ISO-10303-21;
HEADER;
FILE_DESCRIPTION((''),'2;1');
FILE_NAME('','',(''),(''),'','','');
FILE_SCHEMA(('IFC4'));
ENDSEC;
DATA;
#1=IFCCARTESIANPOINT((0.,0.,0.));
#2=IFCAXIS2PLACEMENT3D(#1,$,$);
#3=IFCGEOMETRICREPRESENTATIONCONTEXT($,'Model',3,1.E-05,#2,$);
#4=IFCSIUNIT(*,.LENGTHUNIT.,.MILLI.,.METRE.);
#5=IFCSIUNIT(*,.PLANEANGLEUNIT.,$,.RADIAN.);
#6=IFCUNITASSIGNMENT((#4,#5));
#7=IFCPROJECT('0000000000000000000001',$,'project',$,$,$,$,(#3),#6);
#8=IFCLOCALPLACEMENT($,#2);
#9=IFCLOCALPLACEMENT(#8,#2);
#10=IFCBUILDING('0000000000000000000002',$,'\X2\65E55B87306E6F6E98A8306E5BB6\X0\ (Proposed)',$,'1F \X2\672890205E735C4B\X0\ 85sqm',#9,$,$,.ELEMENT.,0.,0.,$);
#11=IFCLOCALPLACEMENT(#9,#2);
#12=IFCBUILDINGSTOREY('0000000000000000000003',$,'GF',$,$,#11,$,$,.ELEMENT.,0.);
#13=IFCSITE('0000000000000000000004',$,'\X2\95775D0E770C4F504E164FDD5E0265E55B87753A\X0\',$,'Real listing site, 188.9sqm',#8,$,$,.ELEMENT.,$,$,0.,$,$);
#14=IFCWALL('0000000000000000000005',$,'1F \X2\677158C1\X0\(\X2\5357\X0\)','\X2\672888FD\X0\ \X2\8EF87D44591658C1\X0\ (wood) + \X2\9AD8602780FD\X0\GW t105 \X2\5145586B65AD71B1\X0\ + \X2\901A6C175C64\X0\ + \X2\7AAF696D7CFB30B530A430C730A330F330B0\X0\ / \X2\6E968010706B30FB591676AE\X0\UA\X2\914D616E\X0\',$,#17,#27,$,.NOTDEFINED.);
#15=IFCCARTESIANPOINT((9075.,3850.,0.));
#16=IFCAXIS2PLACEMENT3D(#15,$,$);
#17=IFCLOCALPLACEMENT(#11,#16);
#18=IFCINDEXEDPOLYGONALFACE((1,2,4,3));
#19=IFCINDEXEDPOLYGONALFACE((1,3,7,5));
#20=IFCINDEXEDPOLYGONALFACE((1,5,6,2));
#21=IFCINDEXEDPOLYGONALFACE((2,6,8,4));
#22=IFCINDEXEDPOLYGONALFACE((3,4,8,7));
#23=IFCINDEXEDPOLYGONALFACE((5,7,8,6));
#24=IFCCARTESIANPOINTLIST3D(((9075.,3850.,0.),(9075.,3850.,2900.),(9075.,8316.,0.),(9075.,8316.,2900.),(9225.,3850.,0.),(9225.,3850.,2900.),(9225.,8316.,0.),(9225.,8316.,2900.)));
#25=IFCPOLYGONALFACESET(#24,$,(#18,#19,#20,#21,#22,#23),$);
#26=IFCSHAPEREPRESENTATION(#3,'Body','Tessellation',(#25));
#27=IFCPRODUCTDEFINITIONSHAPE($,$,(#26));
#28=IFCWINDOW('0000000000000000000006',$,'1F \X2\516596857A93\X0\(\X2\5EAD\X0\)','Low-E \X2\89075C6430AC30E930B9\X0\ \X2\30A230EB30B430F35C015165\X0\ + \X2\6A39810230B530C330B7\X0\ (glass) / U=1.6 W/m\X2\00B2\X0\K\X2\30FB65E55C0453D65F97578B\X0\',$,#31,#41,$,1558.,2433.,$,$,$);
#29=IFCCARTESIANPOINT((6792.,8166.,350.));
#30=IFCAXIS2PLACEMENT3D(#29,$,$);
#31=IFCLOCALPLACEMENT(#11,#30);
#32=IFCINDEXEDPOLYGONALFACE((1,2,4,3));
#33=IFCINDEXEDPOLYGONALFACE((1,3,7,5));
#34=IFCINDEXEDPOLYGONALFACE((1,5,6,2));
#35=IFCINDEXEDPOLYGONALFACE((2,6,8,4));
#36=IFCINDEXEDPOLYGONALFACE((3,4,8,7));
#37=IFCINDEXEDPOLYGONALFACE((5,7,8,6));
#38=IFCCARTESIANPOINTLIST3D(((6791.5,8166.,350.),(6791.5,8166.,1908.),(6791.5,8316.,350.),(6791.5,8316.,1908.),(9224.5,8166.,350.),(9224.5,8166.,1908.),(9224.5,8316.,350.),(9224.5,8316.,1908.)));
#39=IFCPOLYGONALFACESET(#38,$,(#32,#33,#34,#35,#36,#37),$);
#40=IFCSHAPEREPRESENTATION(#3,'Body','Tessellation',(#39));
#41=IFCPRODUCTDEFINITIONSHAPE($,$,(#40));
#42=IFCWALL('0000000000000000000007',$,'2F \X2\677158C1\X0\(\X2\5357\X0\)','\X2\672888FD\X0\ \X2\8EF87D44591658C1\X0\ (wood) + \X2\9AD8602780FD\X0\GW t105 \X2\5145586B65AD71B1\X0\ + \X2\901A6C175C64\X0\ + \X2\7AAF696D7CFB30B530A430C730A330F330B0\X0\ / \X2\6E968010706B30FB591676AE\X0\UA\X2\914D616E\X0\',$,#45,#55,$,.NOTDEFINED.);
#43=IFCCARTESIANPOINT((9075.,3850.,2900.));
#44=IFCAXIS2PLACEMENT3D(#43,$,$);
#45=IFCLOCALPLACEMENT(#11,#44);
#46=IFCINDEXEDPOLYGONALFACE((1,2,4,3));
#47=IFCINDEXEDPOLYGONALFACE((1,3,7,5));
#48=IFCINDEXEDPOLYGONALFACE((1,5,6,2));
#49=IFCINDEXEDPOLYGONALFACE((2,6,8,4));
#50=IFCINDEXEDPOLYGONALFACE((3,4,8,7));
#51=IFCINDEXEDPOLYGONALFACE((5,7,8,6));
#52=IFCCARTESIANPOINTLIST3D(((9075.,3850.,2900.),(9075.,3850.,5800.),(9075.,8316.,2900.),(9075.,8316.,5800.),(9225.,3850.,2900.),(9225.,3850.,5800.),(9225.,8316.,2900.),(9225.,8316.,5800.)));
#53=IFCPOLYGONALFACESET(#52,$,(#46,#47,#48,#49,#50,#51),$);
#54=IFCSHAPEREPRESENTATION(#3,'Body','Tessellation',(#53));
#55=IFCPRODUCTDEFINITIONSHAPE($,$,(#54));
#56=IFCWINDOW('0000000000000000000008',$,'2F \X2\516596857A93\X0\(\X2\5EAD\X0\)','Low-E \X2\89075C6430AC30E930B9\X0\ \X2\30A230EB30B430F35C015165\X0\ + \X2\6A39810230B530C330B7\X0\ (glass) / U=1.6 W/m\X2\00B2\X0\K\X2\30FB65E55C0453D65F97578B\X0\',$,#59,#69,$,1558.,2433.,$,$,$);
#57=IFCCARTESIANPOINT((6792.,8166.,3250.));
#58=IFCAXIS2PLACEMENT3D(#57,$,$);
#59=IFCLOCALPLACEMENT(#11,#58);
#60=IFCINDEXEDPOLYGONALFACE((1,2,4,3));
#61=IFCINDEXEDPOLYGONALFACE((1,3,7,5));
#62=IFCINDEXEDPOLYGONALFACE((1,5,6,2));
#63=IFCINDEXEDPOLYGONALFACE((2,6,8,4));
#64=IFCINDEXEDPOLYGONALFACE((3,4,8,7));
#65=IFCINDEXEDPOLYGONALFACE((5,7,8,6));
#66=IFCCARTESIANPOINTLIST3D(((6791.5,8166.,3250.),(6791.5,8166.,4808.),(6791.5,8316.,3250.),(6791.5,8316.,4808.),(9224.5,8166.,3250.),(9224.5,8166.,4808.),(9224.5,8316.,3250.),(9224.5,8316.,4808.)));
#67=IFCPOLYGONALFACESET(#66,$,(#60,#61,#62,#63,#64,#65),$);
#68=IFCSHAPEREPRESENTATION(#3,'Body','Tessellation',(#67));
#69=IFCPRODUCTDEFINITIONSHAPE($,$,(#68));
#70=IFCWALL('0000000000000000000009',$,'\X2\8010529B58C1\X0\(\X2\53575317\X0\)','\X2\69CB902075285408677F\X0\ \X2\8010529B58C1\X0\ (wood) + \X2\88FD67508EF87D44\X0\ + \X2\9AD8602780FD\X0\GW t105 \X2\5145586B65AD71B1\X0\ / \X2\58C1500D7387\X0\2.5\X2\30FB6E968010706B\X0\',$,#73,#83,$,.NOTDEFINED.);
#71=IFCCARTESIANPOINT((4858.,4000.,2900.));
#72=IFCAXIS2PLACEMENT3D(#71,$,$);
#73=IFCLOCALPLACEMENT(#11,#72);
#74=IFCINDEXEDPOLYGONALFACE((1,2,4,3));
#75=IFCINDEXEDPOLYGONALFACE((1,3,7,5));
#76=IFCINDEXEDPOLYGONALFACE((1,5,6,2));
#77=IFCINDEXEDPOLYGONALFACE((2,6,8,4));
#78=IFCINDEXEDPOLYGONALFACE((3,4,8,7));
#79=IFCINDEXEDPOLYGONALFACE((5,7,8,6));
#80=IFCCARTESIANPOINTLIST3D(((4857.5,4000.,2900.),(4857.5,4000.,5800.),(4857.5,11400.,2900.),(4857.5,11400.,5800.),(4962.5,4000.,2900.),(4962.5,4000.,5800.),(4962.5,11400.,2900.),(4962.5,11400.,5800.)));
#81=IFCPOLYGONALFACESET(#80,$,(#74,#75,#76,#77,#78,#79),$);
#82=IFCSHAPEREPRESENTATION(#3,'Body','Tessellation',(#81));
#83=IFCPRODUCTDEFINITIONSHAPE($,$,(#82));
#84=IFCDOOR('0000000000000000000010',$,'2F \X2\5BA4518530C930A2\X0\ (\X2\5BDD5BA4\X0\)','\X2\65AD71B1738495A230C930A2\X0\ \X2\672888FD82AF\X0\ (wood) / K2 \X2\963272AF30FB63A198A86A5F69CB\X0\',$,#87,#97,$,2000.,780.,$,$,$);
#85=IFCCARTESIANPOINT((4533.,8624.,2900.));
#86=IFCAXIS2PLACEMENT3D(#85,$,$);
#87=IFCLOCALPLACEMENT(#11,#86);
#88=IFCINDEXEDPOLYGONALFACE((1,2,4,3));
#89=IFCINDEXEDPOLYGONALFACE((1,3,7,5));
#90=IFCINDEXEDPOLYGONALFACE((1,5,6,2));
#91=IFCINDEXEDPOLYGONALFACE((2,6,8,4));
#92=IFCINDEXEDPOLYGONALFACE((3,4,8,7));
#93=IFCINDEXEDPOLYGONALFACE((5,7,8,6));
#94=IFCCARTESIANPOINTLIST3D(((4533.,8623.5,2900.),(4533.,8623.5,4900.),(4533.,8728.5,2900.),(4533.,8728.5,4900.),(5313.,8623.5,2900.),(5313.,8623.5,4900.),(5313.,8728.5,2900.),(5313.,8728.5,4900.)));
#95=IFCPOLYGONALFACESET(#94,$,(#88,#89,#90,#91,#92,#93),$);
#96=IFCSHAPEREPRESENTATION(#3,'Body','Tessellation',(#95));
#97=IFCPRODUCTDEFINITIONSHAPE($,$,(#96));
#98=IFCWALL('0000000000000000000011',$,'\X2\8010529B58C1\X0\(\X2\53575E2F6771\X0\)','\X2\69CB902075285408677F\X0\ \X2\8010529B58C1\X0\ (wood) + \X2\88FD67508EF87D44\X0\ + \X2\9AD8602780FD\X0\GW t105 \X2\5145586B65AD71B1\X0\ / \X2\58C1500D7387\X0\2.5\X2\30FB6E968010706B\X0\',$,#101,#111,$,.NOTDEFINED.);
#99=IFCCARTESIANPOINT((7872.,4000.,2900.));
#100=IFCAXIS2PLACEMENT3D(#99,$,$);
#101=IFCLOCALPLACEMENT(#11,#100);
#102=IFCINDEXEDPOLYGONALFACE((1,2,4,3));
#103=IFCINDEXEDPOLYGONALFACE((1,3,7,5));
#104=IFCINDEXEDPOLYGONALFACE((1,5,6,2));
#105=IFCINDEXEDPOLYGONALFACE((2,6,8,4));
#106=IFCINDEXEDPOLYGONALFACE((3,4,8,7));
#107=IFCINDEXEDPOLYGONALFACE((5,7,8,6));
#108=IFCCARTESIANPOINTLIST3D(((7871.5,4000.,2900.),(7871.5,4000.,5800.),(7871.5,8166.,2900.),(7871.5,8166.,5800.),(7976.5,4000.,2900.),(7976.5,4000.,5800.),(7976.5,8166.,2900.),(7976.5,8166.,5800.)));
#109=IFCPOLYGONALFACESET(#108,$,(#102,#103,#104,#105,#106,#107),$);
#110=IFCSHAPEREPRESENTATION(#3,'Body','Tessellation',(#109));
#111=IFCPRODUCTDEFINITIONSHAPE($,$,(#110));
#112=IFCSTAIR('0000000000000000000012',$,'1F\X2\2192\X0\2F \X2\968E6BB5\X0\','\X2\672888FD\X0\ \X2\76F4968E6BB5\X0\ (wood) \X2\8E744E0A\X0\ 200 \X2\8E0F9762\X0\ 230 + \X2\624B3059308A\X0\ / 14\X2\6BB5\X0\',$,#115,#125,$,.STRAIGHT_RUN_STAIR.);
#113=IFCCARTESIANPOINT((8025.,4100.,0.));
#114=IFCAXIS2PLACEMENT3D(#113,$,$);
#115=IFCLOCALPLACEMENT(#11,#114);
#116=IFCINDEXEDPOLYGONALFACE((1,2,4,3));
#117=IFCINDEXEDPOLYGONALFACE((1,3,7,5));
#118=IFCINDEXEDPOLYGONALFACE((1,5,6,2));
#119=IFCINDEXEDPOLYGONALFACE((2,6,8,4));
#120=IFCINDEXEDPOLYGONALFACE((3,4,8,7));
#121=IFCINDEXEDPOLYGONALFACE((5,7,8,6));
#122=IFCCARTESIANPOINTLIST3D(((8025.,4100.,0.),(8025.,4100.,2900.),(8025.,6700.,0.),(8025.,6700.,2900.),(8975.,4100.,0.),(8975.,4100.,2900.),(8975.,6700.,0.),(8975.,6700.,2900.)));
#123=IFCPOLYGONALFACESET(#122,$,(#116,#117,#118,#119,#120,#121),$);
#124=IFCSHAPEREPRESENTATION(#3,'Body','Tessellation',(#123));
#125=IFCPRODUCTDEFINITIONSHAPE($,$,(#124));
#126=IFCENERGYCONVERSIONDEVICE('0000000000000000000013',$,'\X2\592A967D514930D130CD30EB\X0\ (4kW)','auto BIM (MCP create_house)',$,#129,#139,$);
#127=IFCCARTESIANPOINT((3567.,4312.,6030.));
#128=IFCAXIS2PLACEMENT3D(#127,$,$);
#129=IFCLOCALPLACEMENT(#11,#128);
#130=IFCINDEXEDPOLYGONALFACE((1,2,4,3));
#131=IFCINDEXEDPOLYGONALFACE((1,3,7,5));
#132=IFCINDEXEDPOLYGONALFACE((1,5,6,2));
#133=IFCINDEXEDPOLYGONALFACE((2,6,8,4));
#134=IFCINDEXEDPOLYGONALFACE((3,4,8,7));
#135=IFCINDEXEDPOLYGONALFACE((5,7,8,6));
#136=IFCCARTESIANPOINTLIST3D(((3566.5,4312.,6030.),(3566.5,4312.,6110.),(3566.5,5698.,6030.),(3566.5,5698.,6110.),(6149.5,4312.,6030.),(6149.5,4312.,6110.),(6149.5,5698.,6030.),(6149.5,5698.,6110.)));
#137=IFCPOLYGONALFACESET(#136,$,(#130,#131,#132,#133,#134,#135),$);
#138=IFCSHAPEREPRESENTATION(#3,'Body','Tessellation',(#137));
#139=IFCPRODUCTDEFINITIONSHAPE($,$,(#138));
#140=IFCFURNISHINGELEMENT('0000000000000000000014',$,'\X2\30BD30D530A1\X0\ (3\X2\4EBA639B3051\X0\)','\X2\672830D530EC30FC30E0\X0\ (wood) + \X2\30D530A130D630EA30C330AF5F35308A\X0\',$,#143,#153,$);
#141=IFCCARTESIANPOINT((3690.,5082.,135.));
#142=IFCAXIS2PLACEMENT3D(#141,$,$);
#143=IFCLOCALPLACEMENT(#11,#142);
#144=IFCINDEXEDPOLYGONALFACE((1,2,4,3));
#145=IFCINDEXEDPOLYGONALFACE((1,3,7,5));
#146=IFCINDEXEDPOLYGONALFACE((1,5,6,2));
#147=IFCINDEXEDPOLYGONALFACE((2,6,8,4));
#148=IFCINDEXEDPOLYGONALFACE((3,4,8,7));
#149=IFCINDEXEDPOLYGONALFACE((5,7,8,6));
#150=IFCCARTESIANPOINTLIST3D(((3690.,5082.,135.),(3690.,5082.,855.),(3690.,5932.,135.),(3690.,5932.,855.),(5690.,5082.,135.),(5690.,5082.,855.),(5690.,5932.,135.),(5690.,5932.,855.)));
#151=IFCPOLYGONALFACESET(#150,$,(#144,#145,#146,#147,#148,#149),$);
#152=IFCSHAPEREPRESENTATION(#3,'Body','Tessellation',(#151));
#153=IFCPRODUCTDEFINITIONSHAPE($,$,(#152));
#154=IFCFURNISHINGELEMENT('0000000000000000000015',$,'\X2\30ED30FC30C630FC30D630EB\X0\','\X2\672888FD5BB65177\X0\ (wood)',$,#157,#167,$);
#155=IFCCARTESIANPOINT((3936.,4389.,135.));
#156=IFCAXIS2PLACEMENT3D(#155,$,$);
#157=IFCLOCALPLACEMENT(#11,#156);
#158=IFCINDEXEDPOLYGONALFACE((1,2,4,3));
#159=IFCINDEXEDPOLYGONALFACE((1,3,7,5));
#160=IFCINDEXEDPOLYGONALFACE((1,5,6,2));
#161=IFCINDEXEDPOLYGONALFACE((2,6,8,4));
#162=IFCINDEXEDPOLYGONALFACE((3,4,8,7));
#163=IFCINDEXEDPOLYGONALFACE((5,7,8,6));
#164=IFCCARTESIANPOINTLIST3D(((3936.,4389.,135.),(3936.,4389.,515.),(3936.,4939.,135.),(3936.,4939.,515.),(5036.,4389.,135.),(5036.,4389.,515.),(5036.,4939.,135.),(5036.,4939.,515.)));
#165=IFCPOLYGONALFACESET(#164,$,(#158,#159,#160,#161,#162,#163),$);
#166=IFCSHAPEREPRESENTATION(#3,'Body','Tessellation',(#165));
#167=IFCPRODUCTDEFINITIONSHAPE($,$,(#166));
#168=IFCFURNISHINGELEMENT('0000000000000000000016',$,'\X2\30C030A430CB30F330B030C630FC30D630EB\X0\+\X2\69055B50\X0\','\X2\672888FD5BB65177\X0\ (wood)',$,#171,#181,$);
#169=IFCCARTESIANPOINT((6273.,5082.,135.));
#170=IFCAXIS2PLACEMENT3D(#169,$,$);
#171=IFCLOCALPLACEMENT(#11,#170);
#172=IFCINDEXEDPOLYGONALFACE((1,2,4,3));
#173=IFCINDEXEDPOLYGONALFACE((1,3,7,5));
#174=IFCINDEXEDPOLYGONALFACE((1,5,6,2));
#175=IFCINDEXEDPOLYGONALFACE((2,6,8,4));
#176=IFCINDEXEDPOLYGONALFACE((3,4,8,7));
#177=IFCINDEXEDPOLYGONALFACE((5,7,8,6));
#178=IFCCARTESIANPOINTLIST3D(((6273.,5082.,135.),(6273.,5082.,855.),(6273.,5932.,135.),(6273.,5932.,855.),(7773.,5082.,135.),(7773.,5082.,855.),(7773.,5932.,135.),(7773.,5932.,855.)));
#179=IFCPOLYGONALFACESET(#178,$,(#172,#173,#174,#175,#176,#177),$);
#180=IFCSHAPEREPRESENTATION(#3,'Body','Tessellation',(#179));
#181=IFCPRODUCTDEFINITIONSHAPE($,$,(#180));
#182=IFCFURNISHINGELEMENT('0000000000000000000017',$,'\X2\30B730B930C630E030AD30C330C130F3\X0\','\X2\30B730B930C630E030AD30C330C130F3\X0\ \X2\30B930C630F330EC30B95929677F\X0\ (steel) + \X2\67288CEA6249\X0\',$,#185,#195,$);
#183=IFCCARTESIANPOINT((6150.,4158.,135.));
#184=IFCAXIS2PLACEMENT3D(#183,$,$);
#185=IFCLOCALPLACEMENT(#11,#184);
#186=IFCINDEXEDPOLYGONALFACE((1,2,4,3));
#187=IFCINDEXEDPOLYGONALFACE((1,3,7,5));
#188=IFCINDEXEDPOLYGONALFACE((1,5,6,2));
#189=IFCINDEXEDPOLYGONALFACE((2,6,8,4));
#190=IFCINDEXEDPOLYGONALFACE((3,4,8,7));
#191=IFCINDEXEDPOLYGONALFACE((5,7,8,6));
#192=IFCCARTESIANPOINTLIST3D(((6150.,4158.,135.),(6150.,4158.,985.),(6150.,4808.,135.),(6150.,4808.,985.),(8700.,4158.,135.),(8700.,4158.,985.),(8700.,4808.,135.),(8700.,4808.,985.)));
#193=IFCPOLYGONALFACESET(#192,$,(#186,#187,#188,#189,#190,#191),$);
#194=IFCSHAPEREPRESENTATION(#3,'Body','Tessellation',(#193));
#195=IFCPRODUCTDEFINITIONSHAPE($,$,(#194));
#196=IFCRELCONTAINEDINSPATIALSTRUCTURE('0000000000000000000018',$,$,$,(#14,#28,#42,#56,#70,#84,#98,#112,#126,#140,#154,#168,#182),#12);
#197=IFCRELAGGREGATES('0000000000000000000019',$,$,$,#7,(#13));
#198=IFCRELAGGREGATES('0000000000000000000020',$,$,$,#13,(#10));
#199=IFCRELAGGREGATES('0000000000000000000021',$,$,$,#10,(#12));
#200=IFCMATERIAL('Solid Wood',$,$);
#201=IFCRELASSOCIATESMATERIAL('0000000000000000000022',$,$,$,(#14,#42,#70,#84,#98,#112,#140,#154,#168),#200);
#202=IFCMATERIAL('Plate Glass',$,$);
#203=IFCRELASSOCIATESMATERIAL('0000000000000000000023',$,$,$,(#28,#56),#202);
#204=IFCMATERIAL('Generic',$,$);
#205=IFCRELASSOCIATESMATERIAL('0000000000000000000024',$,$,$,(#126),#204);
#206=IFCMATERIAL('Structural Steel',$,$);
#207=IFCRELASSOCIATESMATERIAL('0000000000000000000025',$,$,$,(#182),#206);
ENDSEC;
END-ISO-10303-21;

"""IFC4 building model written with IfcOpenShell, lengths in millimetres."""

from ifc_helpers import new_model, si_unit, frame, frame_2d, origin, place, context, project, spatial, rectangle, extrude, material, element, fill, save


model = new_model("IFC4")

# Units and contexts
model_context = context("Model", 3, precision=1e-05, world=origin())
ifc_project = project(units=[si_unit("LENGTHUNIT", "METRE", prefix="MILLI"), si_unit("PLANEANGLEUNIT", "RADIAN")], contexts=[model_context])

# Site, building, storey
site_placement = place(None, origin())
site = spatial("IfcSite", under=ifc_project, at=site_placement, Name="長崎県佐世保市日宇町", ObjectType="Real listing site, 188.9sqm", CompositionType="ELEMENT", RefElevation=0.0)
building_placement = place(site_placement, origin())
building = spatial("IfcBuilding", under=site, at=building_placement, Name="日宇の潮風の家 (Proposed)", ObjectType="1F 木造平屋 85sqm", CompositionType="ELEMENT", ElevationOfRefHeight=0.0, ElevationOfTerrain=0.0)
storey_placement = place(building_placement, origin())
storey = spatial("IfcBuildingStorey", under=building, at=storey_placement, Name="GF", CompositionType="ELEMENT", Elevation=0.0)

# Wall, opening, window
ifc_material_1 = material(Name="Solid Wood")
wall_1_placement = place(storey_placement, frame((9075.0, 3850.0, 0.0)))
wall_1 = element("IfcWall", 1, at=wall_1_placement, inside=storey, material=ifc_material_1, Name="1F 東壁(南)", Description="木製 軸組外壁 (wood) + 高性能GW t105 充填断熱 + 通気層 + 窯業系サイディング / 準耐火・外皮UA配慮", PredefinedType="NOTDEFINED", context=model_context, shape_type="SweptSolid", body=[
    extrude(rectangle(XDim=150.0, YDim=4466.0, at=frame_2d((75.0, 2233.0))), frame((9075.0, 3850.0, 0.0)), (0.0, 0.0, 1.0), 2900.0),
])
opening_1_placement = place(storey_placement, frame((6792.0, 8166.0, 350.0)))
opening_1 = element("IfcOpeningElement", 2, at=opening_1_placement, cuts=wall_1, PredefinedType="NOTDEFINED", context=model_context, shape_type="SweptSolid", body=[
    extrude(rectangle(XDim=2433.0, YDim=150.0, at=frame_2d((1216.0, 75.0))), frame((6792.0, 8166.0, 350.0)), (0.0, 0.0, 1.0), 1558.0),
])
ifc_material_2 = material(Name="Plate Glass")
window_1_placement = place(storey_placement, frame((6792.0, 8166.0, 350.0)))
window_1 = element("IfcWindow", 3, at=window_1_placement, inside=storey, material=ifc_material_2, Name="1F 入隅窓(庭)", Description="Low-E 複層ガラス アルゴン封入 + 樹脂サッシ (glass) / U=1.6 W/m²K・日射取得型", OverallHeight=1558.0, OverallWidth=2433.0, context=model_context, shape_type="SweptSolid", body=[
    extrude(rectangle(XDim=2433.0, YDim=150.0, at=frame_2d((1216.0, 75.0))), frame((6792.0, 8166.0, 350.0)), (0.0, 0.0, 1.0), 1558.0),
])
fill(opening_1, window_1)

# Wall, opening, window
wall_2_placement = place(storey_placement, frame((9075.0, 3850.0, 2900.0)))
wall_2 = element("IfcWall", 4, at=wall_2_placement, inside=storey, material=ifc_material_1, Name="2F 東壁(南)", Description="木製 軸組外壁 (wood) + 高性能GW t105 充填断熱 + 通気層 + 窯業系サイディング / 準耐火・外皮UA配慮", PredefinedType="NOTDEFINED", context=model_context, shape_type="SweptSolid", body=[
    extrude(rectangle(XDim=150.0, YDim=4466.0, at=frame_2d((75.0, 2233.0))), frame((9075.0, 3850.0, 2900.0)), (0.0, 0.0, 1.0), 2900.0),
])
opening_2_placement = place(storey_placement, frame((6792.0, 8166.0, 3250.0)))
opening_2 = element("IfcOpeningElement", 5, at=opening_2_placement, cuts=wall_2, PredefinedType="NOTDEFINED", context=model_context, shape_type="SweptSolid", body=[
    extrude(rectangle(XDim=2433.0, YDim=150.0, at=frame_2d((1216.0, 75.0))), frame((6792.0, 8166.0, 3250.0)), (0.0, 0.0, 1.0), 1558.0),
])
window_2_placement = place(storey_placement, frame((6792.0, 8166.0, 3250.0)))
window_2 = element("IfcWindow", 6, at=window_2_placement, inside=storey, material=ifc_material_2, Name="2F 入隅窓(庭)", Description="Low-E 複層ガラス アルゴン封入 + 樹脂サッシ (glass) / U=1.6 W/m²K・日射取得型", OverallHeight=1558.0, OverallWidth=2433.0, context=model_context, shape_type="SweptSolid", body=[
    extrude(rectangle(XDim=2433.0, YDim=150.0, at=frame_2d((1216.0, 75.0))), frame((6792.0, 8166.0, 3250.0)), (0.0, 0.0, 1.0), 1558.0),
])
fill(opening_2, window_2)

# Wall, opening, door
wall_3_placement = place(storey_placement, frame((4858.0, 4000.0, 2900.0)))
wall_3 = element("IfcWall", 7, at=wall_3_placement, inside=storey, material=ifc_material_1, Name="耐力壁(南北)", Description="構造用合板 耐力壁 (wood) + 製材軸組 + 高性能GW t105 充填断熱 / 壁倍率2.5・準耐火", PredefinedType="NOTDEFINED", context=model_context, shape_type="SweptSolid", body=[
    extrude(rectangle(XDim=105.0, YDim=7400.0, at=frame_2d((52.0, 3700.0))), frame((4858.0, 4000.0, 2900.0)), (0.0, 0.0, 1.0), 2900.0),
])
opening_3_placement = place(storey_placement, frame((4533.0, 8624.0, 2900.0)))
opening_3 = element("IfcOpeningElement", 8, at=opening_3_placement, cuts=wall_3, PredefinedType="NOTDEFINED", context=model_context, shape_type="SweptSolid", body=[
    extrude(rectangle(XDim=780.0, YDim=105.0, at=frame_2d((390.0, 52.0))), frame((4533.0, 8624.0, 2900.0)), (0.0, 0.0, 1.0), 2000.0),
])
door_1_placement = place(storey_placement, frame((4533.0, 8624.0, 2900.0)))
door_1 = element("IfcDoor", 9, at=door_1_placement, inside=storey, material=ifc_material_1, Name="2F 室内ドア (寝室)", Description="断熱玄関ドア 木製芯 (wood) / K2 防犯・採風機構", OverallHeight=2000.0, OverallWidth=780.0, context=model_context, shape_type="SweptSolid", body=[
    extrude(rectangle(XDim=780.0, YDim=105.0, at=frame_2d((390.0, 52.0))), frame((4533.0, 8624.0, 2900.0)), (0.0, 0.0, 1.0), 2000.0),
])
fill(opening_3, door_1)

# Wall
wall_4_placement = place(storey_placement, frame((7872.0, 4000.0, 2900.0)))
element("IfcWall", 10, at=wall_4_placement, inside=storey, material=ifc_material_1, Name="耐力壁(南帯東)", Description="構造用合板 耐力壁 (wood) + 製材軸組 + 高性能GW t105 充填断熱 / 壁倍率2.5・準耐火", PredefinedType="NOTDEFINED", context=model_context, shape_type="SweptSolid", body=[
    extrude(rectangle(XDim=105.0, YDim=4166.0, at=frame_2d((52.0, 2083.0))), frame((7872.0, 4000.0, 2900.0)), (0.0, 0.0, 1.0), 2900.0),
])

# Stair
stair_placement = place(storey_placement, frame((8025.0, 4100.0, 0.0)))
element("IfcStair", 11, at=stair_placement, inside=storey, material=ifc_material_1, Name="1F→2F 階段", Description="木製 直階段 (wood) 蹴上 200 踏面 230 + 手すり / 14段", PredefinedType="STRAIGHT_RUN_STAIR", context=model_context, shape_type="SweptSolid", body=[
    extrude(rectangle(XDim=950.0, YDim=2600.0, at=frame_2d((475.0, 1300.0))), frame((8025.0, 4100.0, 0.0)), (0.0, 0.0, 1.0), 2900.0),
])

# Energy conversion device
ifc_material_3 = material(Name="Generic")
energy_conversion_device_placement = place(storey_placement, frame((3567.0, 4312.0, 6030.0)))
element("IfcEnergyConversionDevice", 12, at=energy_conversion_device_placement, inside=storey, material=ifc_material_3, Name="太陽光パネル (4kW)", Description="auto BIM (MCP create_house)", context=model_context, shape_type="SweptSolid", body=[
    extrude(rectangle(XDim=2583.0, YDim=1386.0, at=frame_2d((1291.0, 693.0))), frame((3567.0, 4312.0, 6030.0)), (0.0, 0.0, 1.0), 80.0),
])

# Furnishing elements
furnishing_1_placement = place(storey_placement, frame((3690.0, 5082.0, 135.0)))
element("IfcFurnishingElement", 13, at=furnishing_1_placement, inside=storey, material=ifc_material_1, Name="ソファ (3人掛け)", Description="木フレーム (wood) + ファブリック張り", context=model_context, shape_type="SweptSolid", body=[
    extrude(rectangle(XDim=2000.0, YDim=850.0, at=frame_2d((1000.0, 425.0))), frame((3690.0, 5082.0, 135.0)), (0.0, 0.0, 1.0), 720.0),
])
furnishing_2_placement = place(storey_placement, frame((3936.0, 4389.0, 135.0)))
element("IfcFurnishingElement", 14, at=furnishing_2_placement, inside=storey, material=ifc_material_1, Name="ローテーブル", Description="木製家具 (wood)", context=model_context, shape_type="SweptSolid", body=[
    extrude(rectangle(XDim=1100.0, YDim=550.0, at=frame_2d((550.0, 275.0))), frame((3936.0, 4389.0, 135.0)), (0.0, 0.0, 1.0), 380.0),
])
furnishing_3_placement = place(storey_placement, frame((6273.0, 5082.0, 135.0)))
element("IfcFurnishingElement", 15, at=furnishing_3_placement, inside=storey, material=ifc_material_1, Name="ダイニングテーブル+椅子", Description="木製家具 (wood)", context=model_context, shape_type="SweptSolid", body=[
    extrude(rectangle(XDim=1500.0, YDim=850.0, at=frame_2d((750.0, 425.0))), frame((6273.0, 5082.0, 135.0)), (0.0, 0.0, 1.0), 720.0),
])
ifc_material_4 = material(Name="Structural Steel")
furnishing_4_placement = place(storey_placement, frame((6150.0, 4158.0, 135.0)))
element("IfcFurnishingElement", 16, at=furnishing_4_placement, inside=storey, material=ifc_material_4, Name="システムキッチン", Description="システムキッチン ステンレス天板 (steel) + 木質扉", context=model_context, shape_type="SweptSolid", body=[
    extrude(rectangle(XDim=2550.0, YDim=650.0, at=frame_2d((1275.0, 325.0))), frame((6150.0, 4158.0, 135.0)), (0.0, 0.0, 1.0), 850.0),
])

save(model, "model.ifc")
